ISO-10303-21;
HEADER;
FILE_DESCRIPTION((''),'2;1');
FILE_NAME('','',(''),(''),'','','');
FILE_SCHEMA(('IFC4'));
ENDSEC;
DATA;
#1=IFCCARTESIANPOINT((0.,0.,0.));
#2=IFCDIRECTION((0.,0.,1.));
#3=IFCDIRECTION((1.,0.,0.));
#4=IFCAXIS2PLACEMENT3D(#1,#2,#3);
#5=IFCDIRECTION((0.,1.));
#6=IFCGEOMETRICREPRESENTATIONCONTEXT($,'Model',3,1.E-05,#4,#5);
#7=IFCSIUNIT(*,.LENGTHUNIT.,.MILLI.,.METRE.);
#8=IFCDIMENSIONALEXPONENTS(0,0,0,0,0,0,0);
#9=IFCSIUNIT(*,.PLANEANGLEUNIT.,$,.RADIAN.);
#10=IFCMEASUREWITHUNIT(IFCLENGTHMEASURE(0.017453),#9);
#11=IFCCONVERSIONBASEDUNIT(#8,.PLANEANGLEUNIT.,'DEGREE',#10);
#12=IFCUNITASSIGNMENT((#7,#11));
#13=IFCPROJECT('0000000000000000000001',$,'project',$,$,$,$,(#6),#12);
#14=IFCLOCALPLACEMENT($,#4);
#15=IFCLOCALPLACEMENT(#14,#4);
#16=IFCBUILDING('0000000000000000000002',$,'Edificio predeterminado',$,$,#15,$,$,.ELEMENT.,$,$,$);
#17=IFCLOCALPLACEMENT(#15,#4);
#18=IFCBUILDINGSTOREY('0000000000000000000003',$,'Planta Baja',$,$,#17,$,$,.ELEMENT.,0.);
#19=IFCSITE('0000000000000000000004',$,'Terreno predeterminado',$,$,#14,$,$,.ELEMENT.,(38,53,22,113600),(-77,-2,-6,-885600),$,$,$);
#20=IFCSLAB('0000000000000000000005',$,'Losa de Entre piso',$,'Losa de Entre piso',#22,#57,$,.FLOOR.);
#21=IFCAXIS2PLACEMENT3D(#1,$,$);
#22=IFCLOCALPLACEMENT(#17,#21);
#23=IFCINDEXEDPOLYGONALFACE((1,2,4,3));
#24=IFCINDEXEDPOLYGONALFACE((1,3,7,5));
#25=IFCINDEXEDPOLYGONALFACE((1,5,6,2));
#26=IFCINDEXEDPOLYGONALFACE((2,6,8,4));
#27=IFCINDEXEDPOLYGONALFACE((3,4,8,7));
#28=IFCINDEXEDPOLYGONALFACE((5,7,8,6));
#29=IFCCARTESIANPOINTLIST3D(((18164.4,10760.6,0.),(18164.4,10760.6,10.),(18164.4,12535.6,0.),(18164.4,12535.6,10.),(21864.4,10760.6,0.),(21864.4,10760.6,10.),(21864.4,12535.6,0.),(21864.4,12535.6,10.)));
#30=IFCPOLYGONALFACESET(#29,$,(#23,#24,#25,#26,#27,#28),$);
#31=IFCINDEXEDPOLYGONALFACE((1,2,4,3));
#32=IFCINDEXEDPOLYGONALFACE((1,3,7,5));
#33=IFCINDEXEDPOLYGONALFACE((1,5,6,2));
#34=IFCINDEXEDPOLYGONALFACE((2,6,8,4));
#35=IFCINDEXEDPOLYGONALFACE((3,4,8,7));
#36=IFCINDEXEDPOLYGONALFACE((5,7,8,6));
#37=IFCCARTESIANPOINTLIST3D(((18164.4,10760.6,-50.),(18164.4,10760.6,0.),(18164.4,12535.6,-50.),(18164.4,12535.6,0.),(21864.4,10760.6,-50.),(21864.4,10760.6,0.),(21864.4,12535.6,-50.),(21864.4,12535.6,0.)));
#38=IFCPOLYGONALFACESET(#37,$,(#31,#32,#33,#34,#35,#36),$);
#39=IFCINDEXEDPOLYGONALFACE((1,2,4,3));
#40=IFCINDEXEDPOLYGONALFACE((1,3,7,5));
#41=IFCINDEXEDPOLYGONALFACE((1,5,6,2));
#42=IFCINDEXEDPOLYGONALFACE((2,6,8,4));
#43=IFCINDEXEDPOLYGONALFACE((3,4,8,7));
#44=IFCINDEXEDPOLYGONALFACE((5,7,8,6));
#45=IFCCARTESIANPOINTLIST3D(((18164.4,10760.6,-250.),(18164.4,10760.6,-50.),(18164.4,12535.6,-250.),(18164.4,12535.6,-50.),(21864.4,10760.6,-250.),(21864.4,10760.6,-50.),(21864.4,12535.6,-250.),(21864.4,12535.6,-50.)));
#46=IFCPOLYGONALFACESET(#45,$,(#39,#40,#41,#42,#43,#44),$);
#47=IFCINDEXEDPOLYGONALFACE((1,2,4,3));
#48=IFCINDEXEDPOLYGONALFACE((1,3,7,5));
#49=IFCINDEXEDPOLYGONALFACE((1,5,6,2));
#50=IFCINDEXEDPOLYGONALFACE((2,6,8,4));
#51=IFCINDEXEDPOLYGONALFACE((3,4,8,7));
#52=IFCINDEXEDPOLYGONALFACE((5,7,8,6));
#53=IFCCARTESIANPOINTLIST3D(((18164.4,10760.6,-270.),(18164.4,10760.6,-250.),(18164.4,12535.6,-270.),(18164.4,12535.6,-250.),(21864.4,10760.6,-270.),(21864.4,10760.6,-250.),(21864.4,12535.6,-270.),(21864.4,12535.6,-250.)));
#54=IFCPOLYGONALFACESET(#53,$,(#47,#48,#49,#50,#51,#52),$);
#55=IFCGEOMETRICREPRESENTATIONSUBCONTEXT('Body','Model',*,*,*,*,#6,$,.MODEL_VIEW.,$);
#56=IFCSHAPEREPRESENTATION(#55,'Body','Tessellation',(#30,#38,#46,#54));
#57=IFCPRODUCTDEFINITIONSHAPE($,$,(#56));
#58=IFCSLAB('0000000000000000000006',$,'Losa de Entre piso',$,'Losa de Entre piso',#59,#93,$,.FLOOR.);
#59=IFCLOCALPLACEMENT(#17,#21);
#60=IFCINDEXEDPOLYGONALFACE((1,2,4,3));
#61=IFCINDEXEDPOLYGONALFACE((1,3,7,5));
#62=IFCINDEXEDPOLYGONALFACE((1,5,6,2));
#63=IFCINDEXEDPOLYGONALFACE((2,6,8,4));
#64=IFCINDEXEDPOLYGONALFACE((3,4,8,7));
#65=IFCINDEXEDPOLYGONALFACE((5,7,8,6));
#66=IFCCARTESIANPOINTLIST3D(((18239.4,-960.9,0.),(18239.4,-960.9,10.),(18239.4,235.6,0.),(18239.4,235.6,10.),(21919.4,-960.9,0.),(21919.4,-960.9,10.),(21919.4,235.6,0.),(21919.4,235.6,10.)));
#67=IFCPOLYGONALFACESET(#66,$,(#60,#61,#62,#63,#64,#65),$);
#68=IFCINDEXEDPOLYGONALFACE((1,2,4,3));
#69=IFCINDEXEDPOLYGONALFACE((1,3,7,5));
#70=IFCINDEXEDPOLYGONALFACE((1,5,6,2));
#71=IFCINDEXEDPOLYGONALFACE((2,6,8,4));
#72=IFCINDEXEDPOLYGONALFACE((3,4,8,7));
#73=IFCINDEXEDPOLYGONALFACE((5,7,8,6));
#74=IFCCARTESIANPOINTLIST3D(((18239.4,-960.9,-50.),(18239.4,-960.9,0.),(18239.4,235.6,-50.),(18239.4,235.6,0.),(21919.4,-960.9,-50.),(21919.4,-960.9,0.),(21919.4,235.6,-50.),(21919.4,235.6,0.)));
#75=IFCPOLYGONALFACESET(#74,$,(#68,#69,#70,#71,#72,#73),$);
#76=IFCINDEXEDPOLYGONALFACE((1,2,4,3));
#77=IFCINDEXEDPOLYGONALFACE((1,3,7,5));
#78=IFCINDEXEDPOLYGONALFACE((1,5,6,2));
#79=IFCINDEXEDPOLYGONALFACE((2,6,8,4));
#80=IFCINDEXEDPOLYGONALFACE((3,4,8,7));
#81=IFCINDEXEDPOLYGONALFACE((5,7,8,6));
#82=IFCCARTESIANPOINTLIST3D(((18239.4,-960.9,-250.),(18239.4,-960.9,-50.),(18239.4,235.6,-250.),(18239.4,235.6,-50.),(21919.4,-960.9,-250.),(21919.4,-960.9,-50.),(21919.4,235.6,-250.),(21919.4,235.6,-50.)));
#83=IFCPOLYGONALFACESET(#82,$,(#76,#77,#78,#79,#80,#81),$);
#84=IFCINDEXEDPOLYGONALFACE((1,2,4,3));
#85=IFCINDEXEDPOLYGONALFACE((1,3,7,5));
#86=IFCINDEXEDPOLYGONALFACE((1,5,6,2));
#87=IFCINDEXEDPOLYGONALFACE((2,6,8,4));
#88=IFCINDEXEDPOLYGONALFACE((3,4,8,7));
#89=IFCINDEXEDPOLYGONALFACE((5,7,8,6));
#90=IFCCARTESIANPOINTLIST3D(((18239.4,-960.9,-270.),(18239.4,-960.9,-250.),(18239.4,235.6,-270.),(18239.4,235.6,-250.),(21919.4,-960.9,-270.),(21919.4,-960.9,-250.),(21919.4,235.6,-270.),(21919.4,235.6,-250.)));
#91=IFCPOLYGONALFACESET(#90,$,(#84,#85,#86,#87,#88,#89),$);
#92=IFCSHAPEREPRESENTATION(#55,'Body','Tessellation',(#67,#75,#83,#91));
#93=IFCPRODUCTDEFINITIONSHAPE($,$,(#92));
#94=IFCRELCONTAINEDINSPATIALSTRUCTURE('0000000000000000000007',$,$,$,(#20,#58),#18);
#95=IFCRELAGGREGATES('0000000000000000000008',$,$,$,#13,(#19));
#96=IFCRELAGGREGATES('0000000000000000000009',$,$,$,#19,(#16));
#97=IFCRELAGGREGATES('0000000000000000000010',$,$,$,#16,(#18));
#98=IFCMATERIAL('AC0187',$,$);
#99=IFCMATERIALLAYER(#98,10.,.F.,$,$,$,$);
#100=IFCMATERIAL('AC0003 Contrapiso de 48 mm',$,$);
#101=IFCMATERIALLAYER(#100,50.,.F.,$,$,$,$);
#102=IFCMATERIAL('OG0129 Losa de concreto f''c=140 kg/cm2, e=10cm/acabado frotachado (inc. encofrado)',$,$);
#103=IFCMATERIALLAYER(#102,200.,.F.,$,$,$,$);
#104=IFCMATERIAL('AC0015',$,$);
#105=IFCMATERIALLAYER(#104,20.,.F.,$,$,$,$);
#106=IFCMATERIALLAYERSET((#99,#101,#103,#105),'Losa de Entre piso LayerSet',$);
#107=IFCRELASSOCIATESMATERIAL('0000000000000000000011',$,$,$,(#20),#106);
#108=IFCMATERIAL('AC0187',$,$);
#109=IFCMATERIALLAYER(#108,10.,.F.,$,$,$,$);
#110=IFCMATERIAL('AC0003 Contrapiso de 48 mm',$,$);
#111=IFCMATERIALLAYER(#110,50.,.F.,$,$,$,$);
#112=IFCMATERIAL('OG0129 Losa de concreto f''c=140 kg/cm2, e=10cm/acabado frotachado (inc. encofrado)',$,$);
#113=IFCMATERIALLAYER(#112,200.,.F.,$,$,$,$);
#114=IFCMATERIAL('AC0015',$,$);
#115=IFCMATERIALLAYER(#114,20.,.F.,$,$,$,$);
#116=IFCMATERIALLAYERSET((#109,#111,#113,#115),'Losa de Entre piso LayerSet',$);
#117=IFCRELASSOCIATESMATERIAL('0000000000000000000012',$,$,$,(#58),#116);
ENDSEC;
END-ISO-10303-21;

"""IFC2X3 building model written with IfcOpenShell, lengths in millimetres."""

from ifc_helpers import new_model, entity, si_unit, converted_unit, direction, frame, origin_with_axes, place, context, subcontext, project, spatial, polyline, outline, extrude, material, layer, layer_set, layer_usage, element, save


model = new_model("IFC2X3")

# Units and contexts
model_context = context("Model", 3, precision=1e-05, world=origin_with_axes(), true_north=direction((0.0, 1.0)))
body_context = subcontext(model_context, "Body", "Model", "MODEL_VIEW")
ifc_project = project(units=[si_unit("LENGTHUNIT", "METRE", prefix="MILLI"), converted_unit("PLANEANGLEUNIT", "DEGREE", entity("IfcLengthMeasure", 0.017453), si_unit("PLANEANGLEUNIT", "RADIAN"), dimensions=[0, 0, 0, 0, 0, 0, 0])], contexts=[model_context])

# Site, building, storey
site_placement = place(None, origin_with_axes())
site = spatial("IfcSite", under=ifc_project, at=site_placement, Name="Terreno predeterminado", CompositionType="ELEMENT", RefLatitude=(38, 53, 22, 113600), RefLongitude=(-77, -2, -6, -885600))
building_placement = place(site_placement, origin_with_axes())
building = spatial("IfcBuilding", under=site, at=building_placement, Name="Edificio predeterminado", CompositionType="ELEMENT")
storey_placement = place(building_placement, origin_with_axes())
storey = spatial("IfcBuildingStorey", under=building, at=storey_placement, Name="Planta Baja", CompositionType="ELEMENT", Elevation=0.0)

# Slabs
ifc_material_1 = material(Name="AC0187")
ifc_layer_1 = layer(ifc_material_1, 10.0, ventilated=False)
ifc_material_2 = material(Name="AC0003 Contrapiso de 48 mm")
ifc_layer_2 = layer(ifc_material_2, 50.0, ventilated=False)
ifc_material_3 = material(Name="OG0129 Losa de concreto f'c=140 kg/cm2, e=10cm/acabado frotachado (inc. encofrado)")
ifc_layer_3 = layer(ifc_material_3, 200.0, ventilated=False)
ifc_material_4 = material(Name="AC0015")
ifc_layer_4 = layer(ifc_material_4, 20.0, ventilated=False)
ifc_layer_set_1 = layer_set([ifc_layer_1, ifc_layer_2, ifc_layer_3, ifc_layer_4], Name="Losa de Entre piso LayerSet")
ifc_layer_usage_1 = layer_usage(ifc_layer_set_1, "AXIS3", "POSITIVE", 0.0)
slab_1_placement = place(storey_placement, origin_with_axes())
element("IfcSlab", 1, at=slab_1_placement, inside=storey, material=ifc_layer_usage_1, Name="Losa de Entre piso", ObjectType="Losa de Entre piso", PredefinedType="FLOOR", context=body_context, shape_type="SweptSolid", body=[
    extrude(outline(polyline([(0.0, 0.0), (1775.0, 0.0), (1775.0, 3700.0), (0.0, 3700.0), (0.0, 0.0)])), frame((21864.4, 12535.6, 0.0), z_axis=(0.0, 0.0, -1.0), x_axis=(0.0, -1.0, 0.0)), (0.0, 0.0, -1.0), 10.0),
    extrude(outline(polyline([(0.0, 0.0), (1775.0, 0.0), (1775.0, 3700.0), (0.0, 3700.0), (0.0, 0.0)])), frame((21864.4, 12535.6, -50.0), z_axis=(0.0, 0.0, -1.0), x_axis=(0.0, -1.0, 0.0)), (0.0, 0.0, -1.0), 50.0),
    extrude(outline(polyline([(0.0, 0.0), (1775.0, 0.0), (1775.0, 3700.0), (0.0, 3700.0), (0.0, 0.0)])), frame((21864.4, 12535.6, -250.0), z_axis=(0.0, 0.0, -1.0), x_axis=(0.0, -1.0, 0.0)), (0.0, 0.0, -1.0), 200.0),
    extrude(outline(polyline([(0.0, 0.0), (1775.0, 0.0), (1775.0, 3700.0), (0.0, 3700.0), (0.0, 0.0)])), frame((21864.4, 12535.6, -270.0), z_axis=(0.0, 0.0, -1.0), x_axis=(0.0, -1.0, 0.0)), (0.0, 0.0, -1.0), 20.0),
])
ifc_material_5 = material(Name="AC0187")
ifc_layer_5 = layer(ifc_material_5, 10.0, ventilated=False)
ifc_material_6 = material(Name="AC0003 Contrapiso de 48 mm")
ifc_layer_6 = layer(ifc_material_6, 50.0, ventilated=False)
ifc_material_7 = material(Name="OG0129 Losa de concreto f'c=140 kg/cm2, e=10cm/acabado frotachado (inc. encofrado)")
ifc_layer_7 = layer(ifc_material_7, 200.0, ventilated=False)
ifc_material_8 = material(Name="AC0015")
ifc_layer_8 = layer(ifc_material_8, 20.0, ventilated=False)
ifc_layer_set_2 = layer_set([ifc_layer_5, ifc_layer_6, ifc_layer_7, ifc_layer_8], Name="Losa de Entre piso LayerSet")
ifc_layer_usage_2 = layer_usage(ifc_layer_set_2, "AXIS3", "POSITIVE", 0.0)
slab_2_placement = place(storey_placement, origin_with_axes())
element("IfcSlab", 2, at=slab_2_placement, inside=storey, material=ifc_layer_usage_2, Name="Losa de Entre piso", ObjectType="Losa de Entre piso", PredefinedType="FLOOR", context=body_context, shape_type="SweptSolid", body=[
    extrude(outline(polyline([(0.0, 0.0), (1196.6, 0.0), (1196.6, 3680.0), (0.0, 3680.0), (0.0, 0.0)])), frame((21919.4, 235.6, 0.0), z_axis=(0.0, 0.0, -1.0), x_axis=(0.0, -1.0, 0.0)), (0.0, 0.0, -1.0), 10.0),
    extrude(outline(polyline([(0.0, 0.0), (1196.6, 0.0), (1196.6, 3680.0), (0.0, 3680.0), (0.0, 0.0)])), frame((21919.4, 235.6, -50.0), z_axis=(0.0, 0.0, -1.0), x_axis=(0.0, -1.0, 0.0)), (0.0, 0.0, -1.0), 50.0),
    extrude(outline(polyline([(0.0, 0.0), (1196.6, 0.0), (1196.6, 3680.0), (0.0, 3680.0), (0.0, 0.0)])), frame((21919.4, 235.6, -250.0), z_axis=(0.0, 0.0, -1.0), x_axis=(0.0, -1.0, 0.0)), (0.0, 0.0, -1.0), 200.0),
    extrude(outline(polyline([(0.0, 0.0), (1196.6, 0.0), (1196.6, 3680.0), (0.0, 3680.0), (0.0, 0.0)])), frame((21919.4, 235.6, -270.0), z_axis=(0.0, 0.0, -1.0), x_axis=(0.0, -1.0, 0.0)), (0.0, 0.0, -1.0), 20.0),
])

save(model, "model.ifc")
